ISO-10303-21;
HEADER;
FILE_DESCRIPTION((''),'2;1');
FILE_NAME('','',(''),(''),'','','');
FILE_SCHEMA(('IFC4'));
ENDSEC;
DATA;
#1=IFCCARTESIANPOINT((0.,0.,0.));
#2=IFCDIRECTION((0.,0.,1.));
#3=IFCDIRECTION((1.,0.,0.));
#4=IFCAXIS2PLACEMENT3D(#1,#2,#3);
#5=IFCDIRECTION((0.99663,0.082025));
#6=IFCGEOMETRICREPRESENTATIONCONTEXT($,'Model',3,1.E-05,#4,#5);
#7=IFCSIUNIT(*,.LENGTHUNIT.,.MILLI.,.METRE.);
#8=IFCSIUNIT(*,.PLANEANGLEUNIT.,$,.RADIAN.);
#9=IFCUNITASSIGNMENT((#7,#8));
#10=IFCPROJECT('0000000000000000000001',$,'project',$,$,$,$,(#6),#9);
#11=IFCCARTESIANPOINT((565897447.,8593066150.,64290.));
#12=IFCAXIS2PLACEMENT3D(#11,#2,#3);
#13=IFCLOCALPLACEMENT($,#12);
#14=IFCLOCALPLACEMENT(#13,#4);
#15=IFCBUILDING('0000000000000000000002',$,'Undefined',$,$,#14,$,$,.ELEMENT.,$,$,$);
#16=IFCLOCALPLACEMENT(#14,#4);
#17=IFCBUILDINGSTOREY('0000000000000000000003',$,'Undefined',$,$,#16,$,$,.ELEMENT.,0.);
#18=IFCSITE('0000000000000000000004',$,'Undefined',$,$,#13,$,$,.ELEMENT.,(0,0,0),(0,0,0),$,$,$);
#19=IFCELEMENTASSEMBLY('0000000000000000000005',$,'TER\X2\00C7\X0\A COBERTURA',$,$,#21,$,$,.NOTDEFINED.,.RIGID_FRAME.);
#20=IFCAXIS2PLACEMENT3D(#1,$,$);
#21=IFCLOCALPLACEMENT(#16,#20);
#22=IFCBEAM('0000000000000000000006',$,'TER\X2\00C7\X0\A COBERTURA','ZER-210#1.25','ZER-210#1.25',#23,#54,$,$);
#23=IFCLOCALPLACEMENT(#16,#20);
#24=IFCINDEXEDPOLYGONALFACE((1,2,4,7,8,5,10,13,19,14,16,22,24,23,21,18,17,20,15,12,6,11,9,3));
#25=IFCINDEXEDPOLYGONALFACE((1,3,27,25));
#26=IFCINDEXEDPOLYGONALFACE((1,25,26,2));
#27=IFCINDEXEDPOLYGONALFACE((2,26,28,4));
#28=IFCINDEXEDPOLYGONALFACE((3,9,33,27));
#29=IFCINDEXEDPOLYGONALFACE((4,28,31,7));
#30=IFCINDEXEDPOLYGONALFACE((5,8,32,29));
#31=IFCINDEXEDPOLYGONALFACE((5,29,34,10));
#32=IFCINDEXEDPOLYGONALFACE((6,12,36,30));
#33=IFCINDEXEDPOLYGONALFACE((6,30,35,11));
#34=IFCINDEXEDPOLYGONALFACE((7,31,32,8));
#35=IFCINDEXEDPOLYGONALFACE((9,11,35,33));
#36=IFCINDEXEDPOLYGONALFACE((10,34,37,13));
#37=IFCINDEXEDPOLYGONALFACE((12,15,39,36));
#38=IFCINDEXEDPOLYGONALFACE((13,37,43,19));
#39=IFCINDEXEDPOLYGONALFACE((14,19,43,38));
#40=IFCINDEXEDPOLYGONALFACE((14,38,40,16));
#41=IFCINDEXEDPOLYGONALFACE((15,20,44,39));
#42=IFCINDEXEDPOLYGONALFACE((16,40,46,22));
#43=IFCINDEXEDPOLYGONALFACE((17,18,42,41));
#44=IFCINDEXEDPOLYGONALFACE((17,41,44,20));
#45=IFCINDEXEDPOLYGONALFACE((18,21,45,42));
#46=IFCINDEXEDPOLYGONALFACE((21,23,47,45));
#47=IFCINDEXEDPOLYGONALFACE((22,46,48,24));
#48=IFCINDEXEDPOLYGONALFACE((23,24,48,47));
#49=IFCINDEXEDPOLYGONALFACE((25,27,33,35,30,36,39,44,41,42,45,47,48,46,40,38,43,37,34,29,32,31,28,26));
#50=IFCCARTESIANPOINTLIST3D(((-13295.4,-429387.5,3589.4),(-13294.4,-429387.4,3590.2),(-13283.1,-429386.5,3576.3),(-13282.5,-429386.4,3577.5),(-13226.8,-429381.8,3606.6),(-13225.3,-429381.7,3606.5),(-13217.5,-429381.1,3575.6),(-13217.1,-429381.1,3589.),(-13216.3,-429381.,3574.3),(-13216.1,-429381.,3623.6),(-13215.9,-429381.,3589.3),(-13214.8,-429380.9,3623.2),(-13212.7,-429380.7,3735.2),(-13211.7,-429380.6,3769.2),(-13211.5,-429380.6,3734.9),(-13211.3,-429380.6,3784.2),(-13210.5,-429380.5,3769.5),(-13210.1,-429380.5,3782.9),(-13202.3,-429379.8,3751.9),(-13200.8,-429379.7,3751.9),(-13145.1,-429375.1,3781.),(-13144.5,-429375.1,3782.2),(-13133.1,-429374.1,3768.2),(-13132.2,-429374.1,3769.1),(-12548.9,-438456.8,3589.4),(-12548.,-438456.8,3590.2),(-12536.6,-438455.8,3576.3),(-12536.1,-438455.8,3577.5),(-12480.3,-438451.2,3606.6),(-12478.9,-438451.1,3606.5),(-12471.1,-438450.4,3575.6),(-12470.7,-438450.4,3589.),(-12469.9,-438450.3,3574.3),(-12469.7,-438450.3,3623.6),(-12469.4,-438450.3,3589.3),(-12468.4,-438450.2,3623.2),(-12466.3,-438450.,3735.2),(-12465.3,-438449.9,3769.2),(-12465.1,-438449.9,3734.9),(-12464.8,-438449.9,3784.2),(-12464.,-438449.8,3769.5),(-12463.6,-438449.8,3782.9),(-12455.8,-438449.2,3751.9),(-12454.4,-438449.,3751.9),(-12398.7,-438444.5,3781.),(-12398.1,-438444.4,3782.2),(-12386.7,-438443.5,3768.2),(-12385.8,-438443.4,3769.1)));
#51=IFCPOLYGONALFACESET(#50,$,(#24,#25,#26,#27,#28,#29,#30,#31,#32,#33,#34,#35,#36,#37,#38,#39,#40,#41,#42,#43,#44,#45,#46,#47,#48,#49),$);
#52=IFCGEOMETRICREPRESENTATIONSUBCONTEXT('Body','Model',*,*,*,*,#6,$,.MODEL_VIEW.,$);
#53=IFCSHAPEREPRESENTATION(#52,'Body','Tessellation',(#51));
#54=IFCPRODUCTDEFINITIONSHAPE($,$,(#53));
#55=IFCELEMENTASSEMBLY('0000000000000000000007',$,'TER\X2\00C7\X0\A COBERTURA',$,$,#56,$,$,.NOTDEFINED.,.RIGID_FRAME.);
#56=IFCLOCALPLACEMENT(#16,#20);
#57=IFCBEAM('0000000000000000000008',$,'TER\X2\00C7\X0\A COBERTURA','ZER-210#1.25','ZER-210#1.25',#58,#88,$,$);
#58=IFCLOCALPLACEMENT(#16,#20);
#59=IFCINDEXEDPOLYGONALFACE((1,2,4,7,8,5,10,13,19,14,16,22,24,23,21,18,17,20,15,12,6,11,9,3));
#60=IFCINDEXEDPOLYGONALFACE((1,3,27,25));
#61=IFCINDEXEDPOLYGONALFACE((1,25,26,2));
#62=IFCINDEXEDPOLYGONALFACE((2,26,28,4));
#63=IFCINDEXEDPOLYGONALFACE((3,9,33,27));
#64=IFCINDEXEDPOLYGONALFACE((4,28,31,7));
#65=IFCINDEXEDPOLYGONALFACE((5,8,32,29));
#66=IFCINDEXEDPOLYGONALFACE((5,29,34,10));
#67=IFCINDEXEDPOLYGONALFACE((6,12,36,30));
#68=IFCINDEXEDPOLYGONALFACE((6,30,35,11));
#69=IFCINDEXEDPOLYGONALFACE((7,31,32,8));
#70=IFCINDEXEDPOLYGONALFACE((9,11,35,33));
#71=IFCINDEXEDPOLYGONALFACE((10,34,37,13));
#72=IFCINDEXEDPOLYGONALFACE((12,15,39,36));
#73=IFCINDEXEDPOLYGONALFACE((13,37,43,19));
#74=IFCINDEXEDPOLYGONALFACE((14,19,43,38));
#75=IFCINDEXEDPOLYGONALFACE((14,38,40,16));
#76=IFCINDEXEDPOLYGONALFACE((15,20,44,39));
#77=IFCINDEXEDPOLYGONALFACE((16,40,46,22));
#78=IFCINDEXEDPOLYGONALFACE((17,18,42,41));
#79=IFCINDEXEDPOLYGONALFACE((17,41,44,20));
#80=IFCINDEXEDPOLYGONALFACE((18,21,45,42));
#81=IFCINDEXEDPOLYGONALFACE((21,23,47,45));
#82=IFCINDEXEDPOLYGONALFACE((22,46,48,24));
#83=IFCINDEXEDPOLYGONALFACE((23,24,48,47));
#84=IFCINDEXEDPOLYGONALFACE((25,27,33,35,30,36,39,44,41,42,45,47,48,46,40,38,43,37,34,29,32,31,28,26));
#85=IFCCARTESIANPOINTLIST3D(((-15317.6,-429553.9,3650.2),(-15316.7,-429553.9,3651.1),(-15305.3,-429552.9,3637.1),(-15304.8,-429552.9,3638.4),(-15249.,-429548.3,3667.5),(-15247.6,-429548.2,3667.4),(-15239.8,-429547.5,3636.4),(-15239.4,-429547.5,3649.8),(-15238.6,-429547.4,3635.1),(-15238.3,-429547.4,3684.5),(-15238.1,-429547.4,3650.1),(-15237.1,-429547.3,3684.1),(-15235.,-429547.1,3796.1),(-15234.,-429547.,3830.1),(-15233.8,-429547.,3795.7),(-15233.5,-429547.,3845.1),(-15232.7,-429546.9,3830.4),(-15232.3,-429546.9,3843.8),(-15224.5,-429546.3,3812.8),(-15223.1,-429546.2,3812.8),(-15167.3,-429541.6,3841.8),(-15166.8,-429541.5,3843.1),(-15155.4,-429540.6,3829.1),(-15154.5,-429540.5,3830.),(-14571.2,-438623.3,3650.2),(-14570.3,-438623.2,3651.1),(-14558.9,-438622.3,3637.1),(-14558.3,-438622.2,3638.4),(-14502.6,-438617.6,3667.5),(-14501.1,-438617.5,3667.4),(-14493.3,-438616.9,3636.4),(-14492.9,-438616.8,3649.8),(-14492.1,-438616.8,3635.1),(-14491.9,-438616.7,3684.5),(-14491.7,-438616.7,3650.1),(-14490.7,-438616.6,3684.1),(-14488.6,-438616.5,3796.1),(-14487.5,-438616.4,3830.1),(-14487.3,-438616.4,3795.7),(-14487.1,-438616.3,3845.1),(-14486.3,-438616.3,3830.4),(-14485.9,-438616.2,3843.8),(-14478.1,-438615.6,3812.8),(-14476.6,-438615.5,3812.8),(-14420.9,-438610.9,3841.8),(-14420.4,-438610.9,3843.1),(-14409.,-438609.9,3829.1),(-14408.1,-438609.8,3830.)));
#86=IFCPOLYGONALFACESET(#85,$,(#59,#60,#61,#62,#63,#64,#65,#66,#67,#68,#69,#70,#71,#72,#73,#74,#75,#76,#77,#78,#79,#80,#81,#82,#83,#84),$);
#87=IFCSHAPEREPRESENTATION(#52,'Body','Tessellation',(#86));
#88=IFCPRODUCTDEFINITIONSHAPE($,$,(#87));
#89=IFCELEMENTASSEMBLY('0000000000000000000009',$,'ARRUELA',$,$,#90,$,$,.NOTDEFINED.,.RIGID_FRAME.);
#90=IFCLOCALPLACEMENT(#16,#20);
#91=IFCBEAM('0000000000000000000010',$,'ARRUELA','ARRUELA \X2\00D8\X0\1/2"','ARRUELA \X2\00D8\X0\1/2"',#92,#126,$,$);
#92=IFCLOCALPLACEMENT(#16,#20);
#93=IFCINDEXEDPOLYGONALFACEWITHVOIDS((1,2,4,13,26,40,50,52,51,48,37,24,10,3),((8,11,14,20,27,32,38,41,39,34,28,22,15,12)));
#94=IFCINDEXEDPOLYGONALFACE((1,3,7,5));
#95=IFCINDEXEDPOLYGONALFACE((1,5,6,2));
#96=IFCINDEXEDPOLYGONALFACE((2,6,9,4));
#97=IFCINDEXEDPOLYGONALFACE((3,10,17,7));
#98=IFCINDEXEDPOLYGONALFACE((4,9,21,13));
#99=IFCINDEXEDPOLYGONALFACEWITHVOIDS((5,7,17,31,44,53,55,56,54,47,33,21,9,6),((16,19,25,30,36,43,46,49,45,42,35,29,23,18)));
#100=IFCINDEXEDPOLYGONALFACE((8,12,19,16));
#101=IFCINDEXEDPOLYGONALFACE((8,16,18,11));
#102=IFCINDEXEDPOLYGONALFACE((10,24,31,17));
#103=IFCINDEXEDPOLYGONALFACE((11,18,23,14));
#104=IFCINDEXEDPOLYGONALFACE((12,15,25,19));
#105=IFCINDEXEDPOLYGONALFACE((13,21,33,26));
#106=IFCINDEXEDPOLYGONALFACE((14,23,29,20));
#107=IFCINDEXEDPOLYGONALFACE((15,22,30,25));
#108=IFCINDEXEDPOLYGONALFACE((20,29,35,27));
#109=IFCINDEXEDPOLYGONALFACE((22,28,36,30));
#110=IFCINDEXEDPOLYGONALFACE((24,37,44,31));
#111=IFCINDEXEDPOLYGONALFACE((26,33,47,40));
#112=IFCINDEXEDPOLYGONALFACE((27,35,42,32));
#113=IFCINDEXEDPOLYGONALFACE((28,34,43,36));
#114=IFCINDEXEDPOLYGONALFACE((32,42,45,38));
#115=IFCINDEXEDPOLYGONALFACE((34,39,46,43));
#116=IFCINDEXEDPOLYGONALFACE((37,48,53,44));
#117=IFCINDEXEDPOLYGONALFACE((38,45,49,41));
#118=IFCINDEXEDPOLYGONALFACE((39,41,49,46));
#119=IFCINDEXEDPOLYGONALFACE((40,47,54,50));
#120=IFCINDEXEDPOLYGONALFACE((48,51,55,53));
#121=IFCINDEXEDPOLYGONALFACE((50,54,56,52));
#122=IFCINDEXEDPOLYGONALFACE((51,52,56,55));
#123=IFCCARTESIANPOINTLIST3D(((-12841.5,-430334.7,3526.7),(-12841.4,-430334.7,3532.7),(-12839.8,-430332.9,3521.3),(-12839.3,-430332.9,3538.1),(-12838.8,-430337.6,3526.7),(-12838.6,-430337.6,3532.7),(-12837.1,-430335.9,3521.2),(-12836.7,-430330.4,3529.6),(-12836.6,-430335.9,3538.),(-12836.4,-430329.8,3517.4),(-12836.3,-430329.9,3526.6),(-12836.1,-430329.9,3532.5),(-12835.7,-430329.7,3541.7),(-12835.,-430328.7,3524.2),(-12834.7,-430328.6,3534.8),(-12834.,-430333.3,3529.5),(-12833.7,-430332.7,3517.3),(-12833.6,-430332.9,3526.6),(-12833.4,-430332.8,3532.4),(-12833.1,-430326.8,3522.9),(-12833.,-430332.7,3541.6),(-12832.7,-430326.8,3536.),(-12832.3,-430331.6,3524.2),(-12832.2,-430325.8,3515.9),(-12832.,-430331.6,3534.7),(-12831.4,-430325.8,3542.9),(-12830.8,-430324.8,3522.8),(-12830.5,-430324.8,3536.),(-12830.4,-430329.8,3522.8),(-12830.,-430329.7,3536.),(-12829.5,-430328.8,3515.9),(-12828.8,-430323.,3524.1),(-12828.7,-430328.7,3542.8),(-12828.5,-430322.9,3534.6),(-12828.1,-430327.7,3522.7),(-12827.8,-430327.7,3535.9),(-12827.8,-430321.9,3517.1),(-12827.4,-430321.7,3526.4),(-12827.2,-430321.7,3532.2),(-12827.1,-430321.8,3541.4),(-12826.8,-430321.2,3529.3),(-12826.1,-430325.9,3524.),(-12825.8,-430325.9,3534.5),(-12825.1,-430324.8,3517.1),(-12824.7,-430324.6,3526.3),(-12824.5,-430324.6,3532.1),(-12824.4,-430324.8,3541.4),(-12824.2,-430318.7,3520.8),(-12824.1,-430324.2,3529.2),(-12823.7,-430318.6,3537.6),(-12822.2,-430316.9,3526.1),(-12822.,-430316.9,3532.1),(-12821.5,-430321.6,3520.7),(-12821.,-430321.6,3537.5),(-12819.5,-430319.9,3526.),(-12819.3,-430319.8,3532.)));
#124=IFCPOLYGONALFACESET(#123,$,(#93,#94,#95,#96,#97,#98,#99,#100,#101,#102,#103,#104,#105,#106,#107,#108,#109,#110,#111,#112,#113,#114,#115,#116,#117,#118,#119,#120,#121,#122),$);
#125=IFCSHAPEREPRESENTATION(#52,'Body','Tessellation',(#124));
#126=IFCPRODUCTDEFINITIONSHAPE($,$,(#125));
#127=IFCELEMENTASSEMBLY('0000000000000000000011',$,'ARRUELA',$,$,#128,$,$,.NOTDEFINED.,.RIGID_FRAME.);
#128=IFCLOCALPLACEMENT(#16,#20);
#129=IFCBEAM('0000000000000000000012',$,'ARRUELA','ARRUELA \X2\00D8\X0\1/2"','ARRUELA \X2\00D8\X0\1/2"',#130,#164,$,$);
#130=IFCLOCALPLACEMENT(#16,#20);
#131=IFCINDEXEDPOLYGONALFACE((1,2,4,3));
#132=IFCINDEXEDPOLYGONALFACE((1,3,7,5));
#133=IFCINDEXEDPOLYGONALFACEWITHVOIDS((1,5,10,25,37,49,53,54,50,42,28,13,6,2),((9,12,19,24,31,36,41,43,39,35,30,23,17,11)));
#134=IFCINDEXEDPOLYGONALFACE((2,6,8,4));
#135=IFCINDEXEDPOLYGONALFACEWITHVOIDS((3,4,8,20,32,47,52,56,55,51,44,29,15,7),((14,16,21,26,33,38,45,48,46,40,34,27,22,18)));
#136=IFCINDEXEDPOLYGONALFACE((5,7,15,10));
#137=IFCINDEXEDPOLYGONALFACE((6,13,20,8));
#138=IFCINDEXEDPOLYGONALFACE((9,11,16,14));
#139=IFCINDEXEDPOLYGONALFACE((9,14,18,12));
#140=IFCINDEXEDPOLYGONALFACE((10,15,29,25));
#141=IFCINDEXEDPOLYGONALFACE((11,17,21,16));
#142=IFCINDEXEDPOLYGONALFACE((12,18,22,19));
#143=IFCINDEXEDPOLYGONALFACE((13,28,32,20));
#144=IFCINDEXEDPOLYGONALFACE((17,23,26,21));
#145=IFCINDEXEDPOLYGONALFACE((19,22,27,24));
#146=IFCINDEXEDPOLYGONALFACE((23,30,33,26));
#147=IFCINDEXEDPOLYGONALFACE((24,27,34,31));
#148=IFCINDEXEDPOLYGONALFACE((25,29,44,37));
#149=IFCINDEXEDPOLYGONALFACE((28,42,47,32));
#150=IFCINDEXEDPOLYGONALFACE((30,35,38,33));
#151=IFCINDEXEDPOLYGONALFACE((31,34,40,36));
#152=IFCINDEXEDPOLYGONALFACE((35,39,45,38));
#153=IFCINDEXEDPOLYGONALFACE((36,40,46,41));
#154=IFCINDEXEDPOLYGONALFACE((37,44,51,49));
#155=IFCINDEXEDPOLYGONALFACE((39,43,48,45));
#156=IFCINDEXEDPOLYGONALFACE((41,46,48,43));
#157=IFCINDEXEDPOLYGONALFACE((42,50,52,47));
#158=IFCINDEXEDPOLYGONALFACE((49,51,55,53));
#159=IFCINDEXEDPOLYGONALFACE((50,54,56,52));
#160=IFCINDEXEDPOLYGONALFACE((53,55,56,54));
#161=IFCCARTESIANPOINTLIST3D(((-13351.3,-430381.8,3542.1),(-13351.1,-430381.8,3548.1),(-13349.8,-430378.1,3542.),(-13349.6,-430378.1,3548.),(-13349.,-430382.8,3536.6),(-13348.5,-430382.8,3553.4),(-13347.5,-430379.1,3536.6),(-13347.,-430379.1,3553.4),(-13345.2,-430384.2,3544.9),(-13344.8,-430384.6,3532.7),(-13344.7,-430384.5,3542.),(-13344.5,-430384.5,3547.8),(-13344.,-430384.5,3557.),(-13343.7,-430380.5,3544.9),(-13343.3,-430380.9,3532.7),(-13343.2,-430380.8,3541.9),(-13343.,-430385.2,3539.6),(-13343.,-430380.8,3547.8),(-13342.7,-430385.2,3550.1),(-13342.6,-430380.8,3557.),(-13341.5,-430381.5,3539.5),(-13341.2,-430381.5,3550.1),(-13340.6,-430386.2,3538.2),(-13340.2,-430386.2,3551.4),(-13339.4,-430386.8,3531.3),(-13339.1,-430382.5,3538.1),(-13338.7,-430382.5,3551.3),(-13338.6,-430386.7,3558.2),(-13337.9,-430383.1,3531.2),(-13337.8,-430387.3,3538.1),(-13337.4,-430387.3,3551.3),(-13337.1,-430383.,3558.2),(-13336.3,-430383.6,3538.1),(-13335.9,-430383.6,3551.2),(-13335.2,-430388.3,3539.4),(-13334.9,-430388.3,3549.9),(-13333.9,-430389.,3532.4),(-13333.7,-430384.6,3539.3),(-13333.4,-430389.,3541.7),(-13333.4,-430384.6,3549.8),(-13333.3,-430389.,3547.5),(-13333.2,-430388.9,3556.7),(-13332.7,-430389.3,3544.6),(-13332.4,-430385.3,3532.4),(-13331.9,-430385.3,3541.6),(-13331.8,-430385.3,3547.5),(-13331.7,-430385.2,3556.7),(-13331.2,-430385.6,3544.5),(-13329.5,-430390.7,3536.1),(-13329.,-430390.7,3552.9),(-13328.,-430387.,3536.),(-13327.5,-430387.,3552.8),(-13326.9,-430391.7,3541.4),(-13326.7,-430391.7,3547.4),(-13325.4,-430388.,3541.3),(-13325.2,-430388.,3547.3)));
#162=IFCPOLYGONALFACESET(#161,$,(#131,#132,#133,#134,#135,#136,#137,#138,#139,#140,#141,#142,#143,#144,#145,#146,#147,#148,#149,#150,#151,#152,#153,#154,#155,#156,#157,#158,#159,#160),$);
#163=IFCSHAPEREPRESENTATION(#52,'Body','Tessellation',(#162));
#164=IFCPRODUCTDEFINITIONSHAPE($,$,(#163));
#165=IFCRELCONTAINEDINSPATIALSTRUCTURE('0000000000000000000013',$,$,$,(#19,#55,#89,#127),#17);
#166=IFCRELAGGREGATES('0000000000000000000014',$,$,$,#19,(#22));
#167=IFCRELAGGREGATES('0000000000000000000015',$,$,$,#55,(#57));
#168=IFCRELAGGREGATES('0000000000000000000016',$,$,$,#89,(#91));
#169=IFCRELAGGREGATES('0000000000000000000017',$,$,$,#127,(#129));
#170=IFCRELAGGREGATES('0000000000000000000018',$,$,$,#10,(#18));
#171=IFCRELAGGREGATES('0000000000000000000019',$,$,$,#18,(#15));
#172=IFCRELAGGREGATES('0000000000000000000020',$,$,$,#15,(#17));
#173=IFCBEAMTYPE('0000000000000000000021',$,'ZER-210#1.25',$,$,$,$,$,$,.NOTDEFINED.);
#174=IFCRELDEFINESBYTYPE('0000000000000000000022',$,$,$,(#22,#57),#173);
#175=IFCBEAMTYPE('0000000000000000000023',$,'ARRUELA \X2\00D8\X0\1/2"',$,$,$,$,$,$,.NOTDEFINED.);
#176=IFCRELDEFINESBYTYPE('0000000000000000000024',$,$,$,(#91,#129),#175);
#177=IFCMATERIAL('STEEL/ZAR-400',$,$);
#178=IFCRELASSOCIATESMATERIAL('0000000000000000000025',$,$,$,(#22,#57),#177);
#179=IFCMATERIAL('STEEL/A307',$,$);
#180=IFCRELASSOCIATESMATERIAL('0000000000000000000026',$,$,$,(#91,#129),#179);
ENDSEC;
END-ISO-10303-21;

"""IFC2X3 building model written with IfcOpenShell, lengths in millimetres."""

from ifc_helpers import new_model, si_unit, direction, frame, origin_with_axes, place, context, subcontext, project, spatial, polyline, outline, extrude, material, type_object, element, aggregate, save


model = new_model("IFC2X3")

# Units and contexts
model_context = context("Model", 3, precision=1e-05, world=origin_with_axes(), true_north=direction((0.99663, 0.082025)))
body_context = subcontext(model_context, "Body", "Model", "MODEL_VIEW")
ifc_project = project(units=[si_unit("LENGTHUNIT", "METRE", prefix="MILLI"), si_unit("PLANEANGLEUNIT", "RADIAN")], contexts=[model_context])

# Site, building, storey
site_placement = place(None, frame((565897447.0, 8593066150.0, 64290.0), z_axis=(0.0, 0.0, 1.0), x_axis=(1.0, 0.0, 0.0)))
site = spatial("IfcSite", under=ifc_project, at=site_placement, Name="Undefined", CompositionType="ELEMENT", RefLatitude=(0, 0, 0), RefLongitude=(0, 0, 0))
building_placement = place(site_placement, origin_with_axes())
building = spatial("IfcBuilding", under=site, at=building_placement, Name="Undefined", CompositionType="ELEMENT")
storey_placement = place(building_placement, origin_with_axes())
storey = spatial("IfcBuildingStorey", under=building, at=storey_placement, Name="Undefined", CompositionType="ELEMENT", Elevation=0.0)

# Element assemblies, beams
assembly_1_placement = place(storey_placement, origin_with_axes())
assembly_1 = element("IfcElementAssembly", 1, at=assembly_1_placement, inside=storey, Name="TERÇA COBERTURA", AssemblyPlace="NOTDEFINED", PredefinedType="RIGID_FRAME")
ifc_material_1 = material(Name="STEEL/ZAR-400")
beam_type_1 = type_object("IfcBeamType", Name="ZER-210#1.25", PredefinedType="NOTDEFINED")
beam_1_placement = place(assembly_1_placement, frame((-13213.8, -429380.8, 3679.2), z_axis=(0.029885, 0.00246, 0.99955), x_axis=(0.082025, -0.99663, 0.0)))
beam_1 = element("IfcBeam", 2, at=beam_1_placement, type_object=beam_type_1, material=ifc_material_1, Name="TERÇA COBERTURA", Description="ZER-210#1.25", ObjectType="ZER-210#1.25", context=body_context, shape_type="SweptSolid", body=[
    extrude(outline(polyline([(-65.9, 103.7), (-78.2, 91.4), (-79.1, 92.3), (-66.4, 105.0), (0.6, 105.0), (0.6, 90.0), (-9.4, 73.0), (0.6, 56.0), (0.6, -55.7), (10.8, -73.0), (0.6, -90.3), (0.6, -103.8), (65.9, -103.7), (78.2, -91.4), (79.1, -92.3), (66.4, -105.0), (-0.6, -105.0), (-0.6, -90.0), (9.4, -73.0), (-0.6, -56.0), (-0.6, 55.7), (-10.8, 73.0), (-0.6, 90.3), (-0.6, 103.8), (-65.9, 103.7)])), frame((9100.0, 0.0, 0.0), z_axis=(-1.0, 0.0, 0.0), x_axis=(0.0, -1.0, 0.0)), (0.0, 0.0, 1.0), 9100.0),
])
aggregate(assembly_1, [beam_1])
assembly_2_placement = place(storey_placement, origin_with_axes())
assembly_2 = element("IfcElementAssembly", 3, at=assembly_2_placement, inside=storey, Name="TERÇA COBERTURA", AssemblyPlace="NOTDEFINED", PredefinedType="RIGID_FRAME")
beam_2_placement = place(assembly_2_placement, frame((-15236.0, -429547.2, 3740.1), z_axis=(0.029885, 0.00246, 0.99955), x_axis=(0.082025, -0.99663, 0.0)))
beam_2 = element("IfcBeam", 4, at=beam_2_placement, type_object=beam_type_1, material=ifc_material_1, Name="TERÇA COBERTURA", Description="ZER-210#1.25", ObjectType="ZER-210#1.25", context=body_context, shape_type="SweptSolid", body=[
    extrude(outline(polyline([(-65.9, 103.7), (-78.2, 91.4), (-79.1, 92.3), (-66.4, 105.0), (0.6, 105.0), (0.6, 90.0), (-9.4, 73.0), (0.6, 56.0), (0.6, -55.7), (10.8, -73.0), (0.6, -90.3), (0.6, -103.8), (65.9, -103.7), (78.2, -91.4), (79.1, -92.3), (66.4, -105.0), (-0.6, -105.0), (-0.6, -90.0), (9.4, -73.0), (-0.6, -56.0), (-0.6, 55.7), (-10.8, 73.0), (-0.6, 90.3), (-0.6, 103.8), (-65.9, 103.7)])), frame((9100.0, 0.0, 0.0), z_axis=(-1.0, 0.0, 0.0), x_axis=(0.0, -1.0, 0.0)), (0.0, 0.0, 1.0), 9100.0),
])
aggregate(assembly_2, [beam_2])
assembly_3_placement = place(storey_placement, origin_with_axes())
assembly_3 = element("IfcElementAssembly", 5, at=assembly_3_placement, inside=storey, Name="ARRUELA", AssemblyPlace="NOTDEFINED", PredefinedType="RIGID_FRAME")
ifc_material_2 = material(Name="STEEL/A307")
beam_type_2 = type_object("IfcBeamType", Name="ARRUELA Ø1/2\"", PredefinedType="NOTDEFINED")
beam_3_placement = place(assembly_3_placement, frame((-12831.8, -430325.8, 3529.4), z_axis=(-0.736334, -0.676203, 0.02368), x_axis=(0.675958, -0.736711, -0.018398)))
beam_3 = element("IfcBeam", 6, at=beam_3_placement, type_object=beam_type_2, material=ifc_material_2, Name="ARRUELA", Description="ARRUELA Ø1/2\"", ObjectType="ARRUELA Ø1/2\"", context=body_context, shape_type="SweptSolid", body=[
    extrude(outline(polyline([(-12.2, 5.9), (-8.4, 10.5), (-3.0, 13.2), (3.0, 13.2), (8.4, 10.5), (12.2, 5.9), (13.5, 0.0), (12.2, -5.9), (8.4, -10.5), (3.0, -13.2), (-3.0, -13.2), (-8.4, -10.5), (-12.2, -5.9), (-13.5, 0.0), (-12.2, 5.9)]), holes=[polyline([(5.3, 4.2), (2.9, 6.1), (0.0, 6.8), (-2.9, 6.1), (-5.3, 4.2), (-6.6, 1.5), (-6.6, -1.5), (-5.3, -4.2), (-2.9, -6.1), (0.0, -6.7), (2.9, -6.1), (5.3, -4.2), (6.6, -1.5), (6.6, 1.5), (5.3, 4.2)])]), frame((4.0, 0.0, 0.0), z_axis=(-1.0, 0.0, 0.0), x_axis=(0.0, -1.0, 0.0)), (0.0, 0.0, 1.0), 4.0),
])
aggregate(assembly_3, [beam_3])
assembly_4_placement = place(storey_placement, origin_with_axes())
assembly_4 = element("IfcElementAssembly", 7, at=assembly_4_placement, inside=storey, Name="ARRUELA", AssemblyPlace="NOTDEFINED", PredefinedType="RIGID_FRAME")
beam_4_placement = place(assembly_4_placement, frame((-13337.5, -430383.0, 3544.7), z_axis=(-0.92709, 0.373879, 0.026799), x_axis=(-0.373645, -0.927474, 0.013454)))
beam_4 = element("IfcBeam", 8, at=beam_4_placement, type_object=beam_type_2, material=ifc_material_2, Name="ARRUELA", Description="ARRUELA Ø1/2\"", ObjectType="ARRUELA Ø1/2\"", context=body_context, shape_type="SweptSolid", body=[
    extrude(outline(polyline([(-12.2, 5.9), (-8.4, 10.5), (-3.0, 13.2), (3.0, 13.2), (8.4, 10.5), (12.2, 5.9), (13.5, 0.0), (12.2, -5.9), (8.4, -10.5), (3.0, -13.2), (-3.0, -13.2), (-8.4, -10.5), (-12.2, -5.9), (-13.5, 0.0), (-12.2, 5.9)]), holes=[polyline([(5.3, 4.2), (2.9, 6.1), (0.0, 6.8), (-2.9, 6.1), (-5.3, 4.2), (-6.6, 1.5), (-6.6, -1.5), (-5.3, -4.2), (-2.9, -6.1), (0.0, -6.7), (2.9, -6.1), (5.3, -4.2), (6.6, -1.5), (6.6, 1.5), (5.3, 4.2)])]), frame((4.0, 0.0, 0.0), z_axis=(-1.0, 0.0, 0.0), x_axis=(0.0, -1.0, 0.0)), (0.0, 0.0, 1.0), 4.0),
])
aggregate(assembly_4, [beam_4])

save(model, "model.ifc")
